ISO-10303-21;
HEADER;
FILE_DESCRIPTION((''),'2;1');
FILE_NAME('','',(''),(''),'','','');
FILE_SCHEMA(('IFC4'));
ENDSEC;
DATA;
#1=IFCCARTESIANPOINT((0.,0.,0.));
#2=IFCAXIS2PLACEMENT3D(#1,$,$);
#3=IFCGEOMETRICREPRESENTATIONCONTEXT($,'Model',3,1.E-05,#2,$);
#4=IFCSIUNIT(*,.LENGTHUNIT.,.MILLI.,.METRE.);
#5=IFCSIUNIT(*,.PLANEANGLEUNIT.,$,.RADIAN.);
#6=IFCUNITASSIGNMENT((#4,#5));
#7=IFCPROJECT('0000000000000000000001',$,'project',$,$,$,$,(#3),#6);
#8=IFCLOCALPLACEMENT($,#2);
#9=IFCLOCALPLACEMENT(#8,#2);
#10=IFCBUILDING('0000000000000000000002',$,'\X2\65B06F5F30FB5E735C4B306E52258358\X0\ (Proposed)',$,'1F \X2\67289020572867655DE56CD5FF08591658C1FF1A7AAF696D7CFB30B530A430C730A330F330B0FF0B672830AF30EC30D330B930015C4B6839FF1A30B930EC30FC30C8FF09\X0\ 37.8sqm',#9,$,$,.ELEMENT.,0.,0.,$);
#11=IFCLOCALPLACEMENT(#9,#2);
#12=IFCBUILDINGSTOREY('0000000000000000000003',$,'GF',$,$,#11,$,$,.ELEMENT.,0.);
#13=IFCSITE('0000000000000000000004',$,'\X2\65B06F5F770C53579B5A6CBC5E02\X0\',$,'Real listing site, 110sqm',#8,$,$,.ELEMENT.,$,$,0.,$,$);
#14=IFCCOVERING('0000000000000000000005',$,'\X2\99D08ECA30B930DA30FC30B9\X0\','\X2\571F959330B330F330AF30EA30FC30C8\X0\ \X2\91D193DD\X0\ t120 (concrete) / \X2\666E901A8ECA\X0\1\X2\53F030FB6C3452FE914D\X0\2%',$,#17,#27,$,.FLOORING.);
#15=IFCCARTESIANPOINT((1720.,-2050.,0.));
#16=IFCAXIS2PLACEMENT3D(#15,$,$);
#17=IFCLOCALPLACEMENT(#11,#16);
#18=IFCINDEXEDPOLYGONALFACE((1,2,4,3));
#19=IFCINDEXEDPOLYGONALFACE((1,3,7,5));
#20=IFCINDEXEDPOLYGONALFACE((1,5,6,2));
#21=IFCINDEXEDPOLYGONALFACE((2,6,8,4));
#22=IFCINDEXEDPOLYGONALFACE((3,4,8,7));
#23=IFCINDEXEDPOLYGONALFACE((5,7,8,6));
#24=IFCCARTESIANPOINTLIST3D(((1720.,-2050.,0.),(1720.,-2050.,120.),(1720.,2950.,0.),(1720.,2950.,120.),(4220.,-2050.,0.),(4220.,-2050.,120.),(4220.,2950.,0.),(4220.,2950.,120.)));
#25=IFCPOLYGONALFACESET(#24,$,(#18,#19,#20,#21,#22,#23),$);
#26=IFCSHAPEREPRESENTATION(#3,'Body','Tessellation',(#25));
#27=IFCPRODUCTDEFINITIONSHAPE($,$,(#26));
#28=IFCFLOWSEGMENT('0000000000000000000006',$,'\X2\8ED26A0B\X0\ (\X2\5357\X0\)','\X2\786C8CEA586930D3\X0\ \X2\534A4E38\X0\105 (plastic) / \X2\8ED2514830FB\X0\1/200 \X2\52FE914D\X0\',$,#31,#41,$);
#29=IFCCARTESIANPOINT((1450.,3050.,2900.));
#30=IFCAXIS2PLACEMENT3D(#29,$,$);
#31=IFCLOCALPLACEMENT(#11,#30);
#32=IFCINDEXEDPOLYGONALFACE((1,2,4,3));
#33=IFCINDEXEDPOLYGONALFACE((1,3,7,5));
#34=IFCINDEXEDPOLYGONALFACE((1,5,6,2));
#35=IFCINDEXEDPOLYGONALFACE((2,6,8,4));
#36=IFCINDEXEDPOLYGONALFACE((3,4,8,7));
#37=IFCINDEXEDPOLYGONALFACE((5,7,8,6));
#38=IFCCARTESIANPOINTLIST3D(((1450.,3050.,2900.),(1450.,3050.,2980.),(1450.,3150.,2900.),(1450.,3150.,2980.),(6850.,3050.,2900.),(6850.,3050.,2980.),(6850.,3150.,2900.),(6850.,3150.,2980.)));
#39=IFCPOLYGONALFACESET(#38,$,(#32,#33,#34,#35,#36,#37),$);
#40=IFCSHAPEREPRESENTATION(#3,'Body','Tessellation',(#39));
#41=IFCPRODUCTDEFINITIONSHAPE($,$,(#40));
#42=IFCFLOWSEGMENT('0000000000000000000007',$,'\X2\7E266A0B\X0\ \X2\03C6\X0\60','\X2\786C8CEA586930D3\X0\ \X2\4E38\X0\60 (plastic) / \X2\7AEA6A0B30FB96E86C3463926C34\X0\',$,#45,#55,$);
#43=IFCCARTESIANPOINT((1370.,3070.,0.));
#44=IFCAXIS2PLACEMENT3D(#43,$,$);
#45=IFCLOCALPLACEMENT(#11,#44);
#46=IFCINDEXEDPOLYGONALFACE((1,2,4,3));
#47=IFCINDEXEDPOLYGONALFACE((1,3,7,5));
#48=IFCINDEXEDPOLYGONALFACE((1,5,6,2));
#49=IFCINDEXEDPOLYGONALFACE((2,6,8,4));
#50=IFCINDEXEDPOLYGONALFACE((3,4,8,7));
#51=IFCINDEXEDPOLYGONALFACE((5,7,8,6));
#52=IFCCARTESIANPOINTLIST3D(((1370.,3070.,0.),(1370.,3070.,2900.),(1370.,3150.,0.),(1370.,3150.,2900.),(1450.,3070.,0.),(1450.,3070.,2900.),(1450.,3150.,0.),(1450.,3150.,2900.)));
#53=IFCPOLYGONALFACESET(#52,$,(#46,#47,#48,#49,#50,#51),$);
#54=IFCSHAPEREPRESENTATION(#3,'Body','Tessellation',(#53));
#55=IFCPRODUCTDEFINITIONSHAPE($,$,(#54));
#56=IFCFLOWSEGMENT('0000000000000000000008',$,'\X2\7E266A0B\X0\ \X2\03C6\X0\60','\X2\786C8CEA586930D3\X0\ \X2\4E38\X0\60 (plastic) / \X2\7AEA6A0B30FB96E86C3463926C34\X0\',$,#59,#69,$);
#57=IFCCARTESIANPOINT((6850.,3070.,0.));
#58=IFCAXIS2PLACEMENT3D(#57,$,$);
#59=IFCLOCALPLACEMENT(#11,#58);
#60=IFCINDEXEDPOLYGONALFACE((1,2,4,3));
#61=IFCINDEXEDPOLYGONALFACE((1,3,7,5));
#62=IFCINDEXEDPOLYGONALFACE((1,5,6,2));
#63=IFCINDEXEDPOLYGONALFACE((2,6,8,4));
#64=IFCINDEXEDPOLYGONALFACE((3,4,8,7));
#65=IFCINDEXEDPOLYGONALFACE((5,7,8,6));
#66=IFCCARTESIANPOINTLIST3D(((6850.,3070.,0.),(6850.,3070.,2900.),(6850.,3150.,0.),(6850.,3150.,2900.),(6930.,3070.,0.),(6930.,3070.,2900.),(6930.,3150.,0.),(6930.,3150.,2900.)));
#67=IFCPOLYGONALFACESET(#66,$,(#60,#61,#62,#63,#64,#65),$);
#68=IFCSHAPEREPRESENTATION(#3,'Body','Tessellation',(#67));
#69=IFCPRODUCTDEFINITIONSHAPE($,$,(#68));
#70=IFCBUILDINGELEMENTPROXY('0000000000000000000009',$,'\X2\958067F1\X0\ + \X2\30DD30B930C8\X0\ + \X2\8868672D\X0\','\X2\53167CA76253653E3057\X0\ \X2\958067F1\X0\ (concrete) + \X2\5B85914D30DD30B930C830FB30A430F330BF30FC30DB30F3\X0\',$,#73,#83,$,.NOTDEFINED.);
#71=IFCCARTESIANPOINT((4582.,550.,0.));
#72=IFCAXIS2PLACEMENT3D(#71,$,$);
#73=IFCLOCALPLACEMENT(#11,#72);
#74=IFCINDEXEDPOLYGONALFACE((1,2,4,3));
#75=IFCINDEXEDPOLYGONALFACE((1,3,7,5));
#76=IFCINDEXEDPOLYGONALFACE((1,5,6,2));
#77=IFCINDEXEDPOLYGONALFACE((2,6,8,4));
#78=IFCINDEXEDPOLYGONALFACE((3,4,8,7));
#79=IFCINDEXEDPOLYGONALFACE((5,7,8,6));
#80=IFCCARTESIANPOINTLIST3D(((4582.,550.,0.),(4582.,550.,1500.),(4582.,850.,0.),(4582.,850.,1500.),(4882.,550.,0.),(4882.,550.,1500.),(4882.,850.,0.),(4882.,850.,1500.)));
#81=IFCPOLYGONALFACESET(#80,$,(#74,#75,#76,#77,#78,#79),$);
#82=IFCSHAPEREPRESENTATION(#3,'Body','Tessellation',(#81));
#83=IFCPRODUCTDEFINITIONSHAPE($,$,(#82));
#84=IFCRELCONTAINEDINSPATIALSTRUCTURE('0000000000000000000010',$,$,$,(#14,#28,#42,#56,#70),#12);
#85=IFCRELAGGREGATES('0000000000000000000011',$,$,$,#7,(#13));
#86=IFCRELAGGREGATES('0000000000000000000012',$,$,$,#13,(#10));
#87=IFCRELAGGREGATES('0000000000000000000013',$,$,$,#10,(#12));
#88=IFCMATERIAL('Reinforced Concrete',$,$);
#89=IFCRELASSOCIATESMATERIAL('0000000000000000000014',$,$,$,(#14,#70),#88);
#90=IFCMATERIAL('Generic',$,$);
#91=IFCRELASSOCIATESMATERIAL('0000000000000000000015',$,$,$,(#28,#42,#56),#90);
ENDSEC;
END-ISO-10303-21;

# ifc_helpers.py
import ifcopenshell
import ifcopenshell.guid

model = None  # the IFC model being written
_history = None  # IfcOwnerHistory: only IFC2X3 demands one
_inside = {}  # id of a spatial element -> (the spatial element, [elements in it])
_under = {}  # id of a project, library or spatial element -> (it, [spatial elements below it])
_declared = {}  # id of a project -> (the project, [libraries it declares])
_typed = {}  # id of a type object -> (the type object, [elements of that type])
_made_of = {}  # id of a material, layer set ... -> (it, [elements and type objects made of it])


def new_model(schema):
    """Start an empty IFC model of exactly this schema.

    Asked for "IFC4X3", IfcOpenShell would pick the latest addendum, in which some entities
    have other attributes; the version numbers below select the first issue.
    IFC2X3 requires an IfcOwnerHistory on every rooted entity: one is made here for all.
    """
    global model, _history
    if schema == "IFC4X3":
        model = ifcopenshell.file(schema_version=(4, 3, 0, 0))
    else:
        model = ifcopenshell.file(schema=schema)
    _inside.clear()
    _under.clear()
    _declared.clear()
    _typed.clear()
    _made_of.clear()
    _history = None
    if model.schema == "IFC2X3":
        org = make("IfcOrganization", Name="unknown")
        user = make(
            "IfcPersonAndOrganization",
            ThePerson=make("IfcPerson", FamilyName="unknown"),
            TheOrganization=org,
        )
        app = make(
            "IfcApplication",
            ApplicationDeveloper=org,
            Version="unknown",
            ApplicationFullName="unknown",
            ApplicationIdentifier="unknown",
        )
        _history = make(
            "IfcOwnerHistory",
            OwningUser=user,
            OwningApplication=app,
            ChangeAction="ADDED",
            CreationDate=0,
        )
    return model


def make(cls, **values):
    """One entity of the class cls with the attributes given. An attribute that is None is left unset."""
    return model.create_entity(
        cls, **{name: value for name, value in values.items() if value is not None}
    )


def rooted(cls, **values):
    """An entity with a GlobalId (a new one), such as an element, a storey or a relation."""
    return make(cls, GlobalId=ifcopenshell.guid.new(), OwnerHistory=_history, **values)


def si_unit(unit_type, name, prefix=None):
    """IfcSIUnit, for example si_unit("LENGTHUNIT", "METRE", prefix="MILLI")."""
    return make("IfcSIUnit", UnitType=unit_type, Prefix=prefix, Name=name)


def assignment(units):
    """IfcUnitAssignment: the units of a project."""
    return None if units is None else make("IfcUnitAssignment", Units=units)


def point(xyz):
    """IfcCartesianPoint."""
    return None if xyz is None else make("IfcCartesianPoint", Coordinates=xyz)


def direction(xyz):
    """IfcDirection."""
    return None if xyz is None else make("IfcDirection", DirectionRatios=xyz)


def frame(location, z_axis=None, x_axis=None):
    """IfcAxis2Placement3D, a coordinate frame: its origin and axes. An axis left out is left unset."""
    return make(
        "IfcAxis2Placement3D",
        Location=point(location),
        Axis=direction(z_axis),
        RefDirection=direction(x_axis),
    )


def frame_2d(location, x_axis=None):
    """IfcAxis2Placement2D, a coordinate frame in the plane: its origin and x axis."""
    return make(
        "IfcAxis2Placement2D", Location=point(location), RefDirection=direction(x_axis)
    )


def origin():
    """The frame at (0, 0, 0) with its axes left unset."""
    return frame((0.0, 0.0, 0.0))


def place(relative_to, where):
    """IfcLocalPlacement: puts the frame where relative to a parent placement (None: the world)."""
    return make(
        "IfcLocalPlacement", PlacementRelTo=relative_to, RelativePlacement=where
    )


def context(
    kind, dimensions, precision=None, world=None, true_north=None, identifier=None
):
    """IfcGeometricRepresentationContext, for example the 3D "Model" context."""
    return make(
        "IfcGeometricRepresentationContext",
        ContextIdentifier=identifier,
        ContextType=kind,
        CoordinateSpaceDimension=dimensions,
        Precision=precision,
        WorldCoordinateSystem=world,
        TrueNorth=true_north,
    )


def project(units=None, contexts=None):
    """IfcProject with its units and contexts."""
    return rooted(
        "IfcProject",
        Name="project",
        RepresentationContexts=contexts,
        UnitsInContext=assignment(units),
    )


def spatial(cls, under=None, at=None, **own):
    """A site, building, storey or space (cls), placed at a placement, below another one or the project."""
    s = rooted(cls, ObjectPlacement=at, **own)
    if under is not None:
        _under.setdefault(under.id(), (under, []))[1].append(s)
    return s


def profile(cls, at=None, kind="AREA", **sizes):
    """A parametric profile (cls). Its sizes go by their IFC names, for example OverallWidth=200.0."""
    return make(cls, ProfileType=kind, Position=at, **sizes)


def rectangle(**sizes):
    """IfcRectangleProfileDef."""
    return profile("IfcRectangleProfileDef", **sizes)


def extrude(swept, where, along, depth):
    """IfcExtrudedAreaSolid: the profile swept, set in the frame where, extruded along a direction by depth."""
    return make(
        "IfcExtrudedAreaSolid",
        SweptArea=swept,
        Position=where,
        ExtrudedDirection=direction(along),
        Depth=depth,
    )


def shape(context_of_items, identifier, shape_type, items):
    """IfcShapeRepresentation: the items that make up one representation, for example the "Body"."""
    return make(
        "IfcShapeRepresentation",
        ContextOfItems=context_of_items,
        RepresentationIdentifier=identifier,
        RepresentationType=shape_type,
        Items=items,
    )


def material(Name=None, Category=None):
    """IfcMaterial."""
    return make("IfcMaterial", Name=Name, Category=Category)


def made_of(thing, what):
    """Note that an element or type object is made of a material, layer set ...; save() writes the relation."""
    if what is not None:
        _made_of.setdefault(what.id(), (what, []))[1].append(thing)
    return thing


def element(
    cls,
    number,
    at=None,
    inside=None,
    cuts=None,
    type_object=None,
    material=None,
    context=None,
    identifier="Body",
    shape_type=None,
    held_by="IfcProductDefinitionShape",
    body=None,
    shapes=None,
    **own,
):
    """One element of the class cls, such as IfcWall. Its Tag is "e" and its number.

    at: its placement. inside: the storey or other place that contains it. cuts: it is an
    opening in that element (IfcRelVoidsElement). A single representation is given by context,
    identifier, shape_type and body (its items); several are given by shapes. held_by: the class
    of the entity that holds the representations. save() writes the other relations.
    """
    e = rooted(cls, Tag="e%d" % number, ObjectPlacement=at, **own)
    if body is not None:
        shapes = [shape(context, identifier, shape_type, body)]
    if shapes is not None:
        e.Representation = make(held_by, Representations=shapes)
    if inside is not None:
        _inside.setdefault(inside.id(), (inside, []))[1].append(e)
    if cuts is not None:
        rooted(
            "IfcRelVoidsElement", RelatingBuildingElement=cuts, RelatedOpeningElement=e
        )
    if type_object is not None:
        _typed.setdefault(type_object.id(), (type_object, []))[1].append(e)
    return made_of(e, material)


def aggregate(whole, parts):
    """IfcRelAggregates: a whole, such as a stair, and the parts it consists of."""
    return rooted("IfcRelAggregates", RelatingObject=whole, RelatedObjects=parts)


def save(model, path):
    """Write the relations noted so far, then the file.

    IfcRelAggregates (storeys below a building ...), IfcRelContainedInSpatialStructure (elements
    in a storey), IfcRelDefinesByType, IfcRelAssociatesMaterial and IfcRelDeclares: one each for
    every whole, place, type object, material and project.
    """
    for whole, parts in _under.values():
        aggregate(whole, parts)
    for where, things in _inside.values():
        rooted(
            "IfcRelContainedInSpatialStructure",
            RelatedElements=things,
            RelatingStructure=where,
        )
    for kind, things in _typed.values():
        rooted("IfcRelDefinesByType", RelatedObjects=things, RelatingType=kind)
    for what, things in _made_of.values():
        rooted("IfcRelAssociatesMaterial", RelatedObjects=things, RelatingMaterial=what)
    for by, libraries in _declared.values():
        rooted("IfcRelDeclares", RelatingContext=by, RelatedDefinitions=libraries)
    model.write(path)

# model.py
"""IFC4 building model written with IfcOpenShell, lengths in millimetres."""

from ifc_helpers import new_model, si_unit, frame, frame_2d, origin, place, context, project, spatial, rectangle, extrude, material, element, save


model = new_model("IFC4")

# Units and contexts
model_context = context("Model", 3, precision=1e-05, world=origin())
ifc_project = project(units=[si_unit("LENGTHUNIT", "METRE", prefix="MILLI"), si_unit("PLANEANGLEUNIT", "RADIAN")], contexts=[model_context])

# Site, building, storey
site_placement = place(None, origin())
site = spatial("IfcSite", under=ifc_project, at=site_placement, Name="新潟県南魚沼市", ObjectType="Real listing site, 110sqm", CompositionType="ELEMENT", RefElevation=0.0)
building_placement = place(site_placement, origin())
building = spatial("IfcBuilding", under=site, at=building_placement, Name="新潟・平屋の別荘 (Proposed)", ObjectType="1F 木造在来工法（外壁：窯業系サイディング＋木クレビス、屋根：スレート） 37.8sqm", CompositionType="ELEMENT", ElevationOfRefHeight=0.0, ElevationOfTerrain=0.0)
storey_placement = place(building_placement, origin())
storey = spatial("IfcBuildingStorey", under=building, at=storey_placement, Name="GF", CompositionType="ELEMENT", Elevation=0.0)

# Shared definitions
ifc_material_1 = material(Name="Reinforced Concrete")

# Covering
covering_1_placement = place(storey_placement, frame((1720.0, -2050.0, 0.0)))
element("IfcCovering", 1, at=covering_1_placement, inside=storey, material=ifc_material_1, Name="駐車スペース", Description="土間コンクリート 金鏝 t120 (concrete) / 普通車1台・水勾配2%", PredefinedType="FLOORING", context=model_context, shape_type="SweptSolid", body=[
    extrude(rectangle(XDim=2500.0, YDim=5000.0, at=frame_2d((1250.0, 2500.0))), frame((1720.0, -2050.0, 0.0)), (0.0, 0.0, 1.0), 120.0),
])

# Flow segments
ifc_material_2 = material(Name="Generic")
flow_segment_1_placement = place(storey_placement, frame((1450.0, 3050.0, 2900.0)))
element("IfcFlowSegment", 2, at=flow_segment_1_placement, inside=storey, material=ifc_material_2, Name="軒樋 (南)", Description="硬質塩ビ 半丸105 (plastic) / 軒先・1/200 勾配", context=model_context, shape_type="SweptSolid", body=[
    extrude(rectangle(XDim=5400.0, YDim=100.0, at=frame_2d((2700.0, 50.0))), frame((1450.0, 3050.0, 2900.0)), (0.0, 0.0, 1.0), 80.0),
])
flow_segment_2_placement = place(storey_placement, frame((1370.0, 3070.0, 0.0)))
element("IfcFlowSegment", 3, at=flow_segment_2_placement, inside=storey, material=ifc_material_2, Name="縦樋 φ60", Description="硬質塩ビ 丸60 (plastic) / 竪樋・雨水排水", context=model_context, shape_type="SweptSolid", body=[
    extrude(rectangle(XDim=80.0, YDim=80.0, at=frame_2d((40.0, 40.0))), frame((1370.0, 3070.0, 0.0)), (0.0, 0.0, 1.0), 2900.0),
])
flow_segment_3_placement = place(storey_placement, frame((6850.0, 3070.0, 0.0)))
element("IfcFlowSegment", 4, at=flow_segment_3_placement, inside=storey, material=ifc_material_2, Name="縦樋 φ60", Description="硬質塩ビ 丸60 (plastic) / 竪樋・雨水排水", context=model_context, shape_type="SweptSolid", body=[
    extrude(rectangle(XDim=80.0, YDim=80.0, at=frame_2d((40.0, 40.0))), frame((6850.0, 3070.0, 0.0)), (0.0, 0.0, 1.0), 2900.0),
])

# Building element proxy
proxy_placement = place(storey_placement, frame((4582.0, 550.0, 0.0)))
element("IfcBuildingElementProxy", 5, at=proxy_placement, inside=storey, material=ifc_material_1, Name="門柱 + ポスト + 表札", Description="化粧打放し 門柱 (concrete) + 宅配ポスト・インターホン", PredefinedType="NOTDEFINED", context=model_context, shape_type="SweptSolid", body=[
    extrude(rectangle(XDim=300.0, YDim=300.0, at=frame_2d((150.0, 150.0))), frame((4582.0, 550.0, 0.0)), (0.0, 0.0, 1.0), 1500.0),
])

save(model, "model.ifc")
